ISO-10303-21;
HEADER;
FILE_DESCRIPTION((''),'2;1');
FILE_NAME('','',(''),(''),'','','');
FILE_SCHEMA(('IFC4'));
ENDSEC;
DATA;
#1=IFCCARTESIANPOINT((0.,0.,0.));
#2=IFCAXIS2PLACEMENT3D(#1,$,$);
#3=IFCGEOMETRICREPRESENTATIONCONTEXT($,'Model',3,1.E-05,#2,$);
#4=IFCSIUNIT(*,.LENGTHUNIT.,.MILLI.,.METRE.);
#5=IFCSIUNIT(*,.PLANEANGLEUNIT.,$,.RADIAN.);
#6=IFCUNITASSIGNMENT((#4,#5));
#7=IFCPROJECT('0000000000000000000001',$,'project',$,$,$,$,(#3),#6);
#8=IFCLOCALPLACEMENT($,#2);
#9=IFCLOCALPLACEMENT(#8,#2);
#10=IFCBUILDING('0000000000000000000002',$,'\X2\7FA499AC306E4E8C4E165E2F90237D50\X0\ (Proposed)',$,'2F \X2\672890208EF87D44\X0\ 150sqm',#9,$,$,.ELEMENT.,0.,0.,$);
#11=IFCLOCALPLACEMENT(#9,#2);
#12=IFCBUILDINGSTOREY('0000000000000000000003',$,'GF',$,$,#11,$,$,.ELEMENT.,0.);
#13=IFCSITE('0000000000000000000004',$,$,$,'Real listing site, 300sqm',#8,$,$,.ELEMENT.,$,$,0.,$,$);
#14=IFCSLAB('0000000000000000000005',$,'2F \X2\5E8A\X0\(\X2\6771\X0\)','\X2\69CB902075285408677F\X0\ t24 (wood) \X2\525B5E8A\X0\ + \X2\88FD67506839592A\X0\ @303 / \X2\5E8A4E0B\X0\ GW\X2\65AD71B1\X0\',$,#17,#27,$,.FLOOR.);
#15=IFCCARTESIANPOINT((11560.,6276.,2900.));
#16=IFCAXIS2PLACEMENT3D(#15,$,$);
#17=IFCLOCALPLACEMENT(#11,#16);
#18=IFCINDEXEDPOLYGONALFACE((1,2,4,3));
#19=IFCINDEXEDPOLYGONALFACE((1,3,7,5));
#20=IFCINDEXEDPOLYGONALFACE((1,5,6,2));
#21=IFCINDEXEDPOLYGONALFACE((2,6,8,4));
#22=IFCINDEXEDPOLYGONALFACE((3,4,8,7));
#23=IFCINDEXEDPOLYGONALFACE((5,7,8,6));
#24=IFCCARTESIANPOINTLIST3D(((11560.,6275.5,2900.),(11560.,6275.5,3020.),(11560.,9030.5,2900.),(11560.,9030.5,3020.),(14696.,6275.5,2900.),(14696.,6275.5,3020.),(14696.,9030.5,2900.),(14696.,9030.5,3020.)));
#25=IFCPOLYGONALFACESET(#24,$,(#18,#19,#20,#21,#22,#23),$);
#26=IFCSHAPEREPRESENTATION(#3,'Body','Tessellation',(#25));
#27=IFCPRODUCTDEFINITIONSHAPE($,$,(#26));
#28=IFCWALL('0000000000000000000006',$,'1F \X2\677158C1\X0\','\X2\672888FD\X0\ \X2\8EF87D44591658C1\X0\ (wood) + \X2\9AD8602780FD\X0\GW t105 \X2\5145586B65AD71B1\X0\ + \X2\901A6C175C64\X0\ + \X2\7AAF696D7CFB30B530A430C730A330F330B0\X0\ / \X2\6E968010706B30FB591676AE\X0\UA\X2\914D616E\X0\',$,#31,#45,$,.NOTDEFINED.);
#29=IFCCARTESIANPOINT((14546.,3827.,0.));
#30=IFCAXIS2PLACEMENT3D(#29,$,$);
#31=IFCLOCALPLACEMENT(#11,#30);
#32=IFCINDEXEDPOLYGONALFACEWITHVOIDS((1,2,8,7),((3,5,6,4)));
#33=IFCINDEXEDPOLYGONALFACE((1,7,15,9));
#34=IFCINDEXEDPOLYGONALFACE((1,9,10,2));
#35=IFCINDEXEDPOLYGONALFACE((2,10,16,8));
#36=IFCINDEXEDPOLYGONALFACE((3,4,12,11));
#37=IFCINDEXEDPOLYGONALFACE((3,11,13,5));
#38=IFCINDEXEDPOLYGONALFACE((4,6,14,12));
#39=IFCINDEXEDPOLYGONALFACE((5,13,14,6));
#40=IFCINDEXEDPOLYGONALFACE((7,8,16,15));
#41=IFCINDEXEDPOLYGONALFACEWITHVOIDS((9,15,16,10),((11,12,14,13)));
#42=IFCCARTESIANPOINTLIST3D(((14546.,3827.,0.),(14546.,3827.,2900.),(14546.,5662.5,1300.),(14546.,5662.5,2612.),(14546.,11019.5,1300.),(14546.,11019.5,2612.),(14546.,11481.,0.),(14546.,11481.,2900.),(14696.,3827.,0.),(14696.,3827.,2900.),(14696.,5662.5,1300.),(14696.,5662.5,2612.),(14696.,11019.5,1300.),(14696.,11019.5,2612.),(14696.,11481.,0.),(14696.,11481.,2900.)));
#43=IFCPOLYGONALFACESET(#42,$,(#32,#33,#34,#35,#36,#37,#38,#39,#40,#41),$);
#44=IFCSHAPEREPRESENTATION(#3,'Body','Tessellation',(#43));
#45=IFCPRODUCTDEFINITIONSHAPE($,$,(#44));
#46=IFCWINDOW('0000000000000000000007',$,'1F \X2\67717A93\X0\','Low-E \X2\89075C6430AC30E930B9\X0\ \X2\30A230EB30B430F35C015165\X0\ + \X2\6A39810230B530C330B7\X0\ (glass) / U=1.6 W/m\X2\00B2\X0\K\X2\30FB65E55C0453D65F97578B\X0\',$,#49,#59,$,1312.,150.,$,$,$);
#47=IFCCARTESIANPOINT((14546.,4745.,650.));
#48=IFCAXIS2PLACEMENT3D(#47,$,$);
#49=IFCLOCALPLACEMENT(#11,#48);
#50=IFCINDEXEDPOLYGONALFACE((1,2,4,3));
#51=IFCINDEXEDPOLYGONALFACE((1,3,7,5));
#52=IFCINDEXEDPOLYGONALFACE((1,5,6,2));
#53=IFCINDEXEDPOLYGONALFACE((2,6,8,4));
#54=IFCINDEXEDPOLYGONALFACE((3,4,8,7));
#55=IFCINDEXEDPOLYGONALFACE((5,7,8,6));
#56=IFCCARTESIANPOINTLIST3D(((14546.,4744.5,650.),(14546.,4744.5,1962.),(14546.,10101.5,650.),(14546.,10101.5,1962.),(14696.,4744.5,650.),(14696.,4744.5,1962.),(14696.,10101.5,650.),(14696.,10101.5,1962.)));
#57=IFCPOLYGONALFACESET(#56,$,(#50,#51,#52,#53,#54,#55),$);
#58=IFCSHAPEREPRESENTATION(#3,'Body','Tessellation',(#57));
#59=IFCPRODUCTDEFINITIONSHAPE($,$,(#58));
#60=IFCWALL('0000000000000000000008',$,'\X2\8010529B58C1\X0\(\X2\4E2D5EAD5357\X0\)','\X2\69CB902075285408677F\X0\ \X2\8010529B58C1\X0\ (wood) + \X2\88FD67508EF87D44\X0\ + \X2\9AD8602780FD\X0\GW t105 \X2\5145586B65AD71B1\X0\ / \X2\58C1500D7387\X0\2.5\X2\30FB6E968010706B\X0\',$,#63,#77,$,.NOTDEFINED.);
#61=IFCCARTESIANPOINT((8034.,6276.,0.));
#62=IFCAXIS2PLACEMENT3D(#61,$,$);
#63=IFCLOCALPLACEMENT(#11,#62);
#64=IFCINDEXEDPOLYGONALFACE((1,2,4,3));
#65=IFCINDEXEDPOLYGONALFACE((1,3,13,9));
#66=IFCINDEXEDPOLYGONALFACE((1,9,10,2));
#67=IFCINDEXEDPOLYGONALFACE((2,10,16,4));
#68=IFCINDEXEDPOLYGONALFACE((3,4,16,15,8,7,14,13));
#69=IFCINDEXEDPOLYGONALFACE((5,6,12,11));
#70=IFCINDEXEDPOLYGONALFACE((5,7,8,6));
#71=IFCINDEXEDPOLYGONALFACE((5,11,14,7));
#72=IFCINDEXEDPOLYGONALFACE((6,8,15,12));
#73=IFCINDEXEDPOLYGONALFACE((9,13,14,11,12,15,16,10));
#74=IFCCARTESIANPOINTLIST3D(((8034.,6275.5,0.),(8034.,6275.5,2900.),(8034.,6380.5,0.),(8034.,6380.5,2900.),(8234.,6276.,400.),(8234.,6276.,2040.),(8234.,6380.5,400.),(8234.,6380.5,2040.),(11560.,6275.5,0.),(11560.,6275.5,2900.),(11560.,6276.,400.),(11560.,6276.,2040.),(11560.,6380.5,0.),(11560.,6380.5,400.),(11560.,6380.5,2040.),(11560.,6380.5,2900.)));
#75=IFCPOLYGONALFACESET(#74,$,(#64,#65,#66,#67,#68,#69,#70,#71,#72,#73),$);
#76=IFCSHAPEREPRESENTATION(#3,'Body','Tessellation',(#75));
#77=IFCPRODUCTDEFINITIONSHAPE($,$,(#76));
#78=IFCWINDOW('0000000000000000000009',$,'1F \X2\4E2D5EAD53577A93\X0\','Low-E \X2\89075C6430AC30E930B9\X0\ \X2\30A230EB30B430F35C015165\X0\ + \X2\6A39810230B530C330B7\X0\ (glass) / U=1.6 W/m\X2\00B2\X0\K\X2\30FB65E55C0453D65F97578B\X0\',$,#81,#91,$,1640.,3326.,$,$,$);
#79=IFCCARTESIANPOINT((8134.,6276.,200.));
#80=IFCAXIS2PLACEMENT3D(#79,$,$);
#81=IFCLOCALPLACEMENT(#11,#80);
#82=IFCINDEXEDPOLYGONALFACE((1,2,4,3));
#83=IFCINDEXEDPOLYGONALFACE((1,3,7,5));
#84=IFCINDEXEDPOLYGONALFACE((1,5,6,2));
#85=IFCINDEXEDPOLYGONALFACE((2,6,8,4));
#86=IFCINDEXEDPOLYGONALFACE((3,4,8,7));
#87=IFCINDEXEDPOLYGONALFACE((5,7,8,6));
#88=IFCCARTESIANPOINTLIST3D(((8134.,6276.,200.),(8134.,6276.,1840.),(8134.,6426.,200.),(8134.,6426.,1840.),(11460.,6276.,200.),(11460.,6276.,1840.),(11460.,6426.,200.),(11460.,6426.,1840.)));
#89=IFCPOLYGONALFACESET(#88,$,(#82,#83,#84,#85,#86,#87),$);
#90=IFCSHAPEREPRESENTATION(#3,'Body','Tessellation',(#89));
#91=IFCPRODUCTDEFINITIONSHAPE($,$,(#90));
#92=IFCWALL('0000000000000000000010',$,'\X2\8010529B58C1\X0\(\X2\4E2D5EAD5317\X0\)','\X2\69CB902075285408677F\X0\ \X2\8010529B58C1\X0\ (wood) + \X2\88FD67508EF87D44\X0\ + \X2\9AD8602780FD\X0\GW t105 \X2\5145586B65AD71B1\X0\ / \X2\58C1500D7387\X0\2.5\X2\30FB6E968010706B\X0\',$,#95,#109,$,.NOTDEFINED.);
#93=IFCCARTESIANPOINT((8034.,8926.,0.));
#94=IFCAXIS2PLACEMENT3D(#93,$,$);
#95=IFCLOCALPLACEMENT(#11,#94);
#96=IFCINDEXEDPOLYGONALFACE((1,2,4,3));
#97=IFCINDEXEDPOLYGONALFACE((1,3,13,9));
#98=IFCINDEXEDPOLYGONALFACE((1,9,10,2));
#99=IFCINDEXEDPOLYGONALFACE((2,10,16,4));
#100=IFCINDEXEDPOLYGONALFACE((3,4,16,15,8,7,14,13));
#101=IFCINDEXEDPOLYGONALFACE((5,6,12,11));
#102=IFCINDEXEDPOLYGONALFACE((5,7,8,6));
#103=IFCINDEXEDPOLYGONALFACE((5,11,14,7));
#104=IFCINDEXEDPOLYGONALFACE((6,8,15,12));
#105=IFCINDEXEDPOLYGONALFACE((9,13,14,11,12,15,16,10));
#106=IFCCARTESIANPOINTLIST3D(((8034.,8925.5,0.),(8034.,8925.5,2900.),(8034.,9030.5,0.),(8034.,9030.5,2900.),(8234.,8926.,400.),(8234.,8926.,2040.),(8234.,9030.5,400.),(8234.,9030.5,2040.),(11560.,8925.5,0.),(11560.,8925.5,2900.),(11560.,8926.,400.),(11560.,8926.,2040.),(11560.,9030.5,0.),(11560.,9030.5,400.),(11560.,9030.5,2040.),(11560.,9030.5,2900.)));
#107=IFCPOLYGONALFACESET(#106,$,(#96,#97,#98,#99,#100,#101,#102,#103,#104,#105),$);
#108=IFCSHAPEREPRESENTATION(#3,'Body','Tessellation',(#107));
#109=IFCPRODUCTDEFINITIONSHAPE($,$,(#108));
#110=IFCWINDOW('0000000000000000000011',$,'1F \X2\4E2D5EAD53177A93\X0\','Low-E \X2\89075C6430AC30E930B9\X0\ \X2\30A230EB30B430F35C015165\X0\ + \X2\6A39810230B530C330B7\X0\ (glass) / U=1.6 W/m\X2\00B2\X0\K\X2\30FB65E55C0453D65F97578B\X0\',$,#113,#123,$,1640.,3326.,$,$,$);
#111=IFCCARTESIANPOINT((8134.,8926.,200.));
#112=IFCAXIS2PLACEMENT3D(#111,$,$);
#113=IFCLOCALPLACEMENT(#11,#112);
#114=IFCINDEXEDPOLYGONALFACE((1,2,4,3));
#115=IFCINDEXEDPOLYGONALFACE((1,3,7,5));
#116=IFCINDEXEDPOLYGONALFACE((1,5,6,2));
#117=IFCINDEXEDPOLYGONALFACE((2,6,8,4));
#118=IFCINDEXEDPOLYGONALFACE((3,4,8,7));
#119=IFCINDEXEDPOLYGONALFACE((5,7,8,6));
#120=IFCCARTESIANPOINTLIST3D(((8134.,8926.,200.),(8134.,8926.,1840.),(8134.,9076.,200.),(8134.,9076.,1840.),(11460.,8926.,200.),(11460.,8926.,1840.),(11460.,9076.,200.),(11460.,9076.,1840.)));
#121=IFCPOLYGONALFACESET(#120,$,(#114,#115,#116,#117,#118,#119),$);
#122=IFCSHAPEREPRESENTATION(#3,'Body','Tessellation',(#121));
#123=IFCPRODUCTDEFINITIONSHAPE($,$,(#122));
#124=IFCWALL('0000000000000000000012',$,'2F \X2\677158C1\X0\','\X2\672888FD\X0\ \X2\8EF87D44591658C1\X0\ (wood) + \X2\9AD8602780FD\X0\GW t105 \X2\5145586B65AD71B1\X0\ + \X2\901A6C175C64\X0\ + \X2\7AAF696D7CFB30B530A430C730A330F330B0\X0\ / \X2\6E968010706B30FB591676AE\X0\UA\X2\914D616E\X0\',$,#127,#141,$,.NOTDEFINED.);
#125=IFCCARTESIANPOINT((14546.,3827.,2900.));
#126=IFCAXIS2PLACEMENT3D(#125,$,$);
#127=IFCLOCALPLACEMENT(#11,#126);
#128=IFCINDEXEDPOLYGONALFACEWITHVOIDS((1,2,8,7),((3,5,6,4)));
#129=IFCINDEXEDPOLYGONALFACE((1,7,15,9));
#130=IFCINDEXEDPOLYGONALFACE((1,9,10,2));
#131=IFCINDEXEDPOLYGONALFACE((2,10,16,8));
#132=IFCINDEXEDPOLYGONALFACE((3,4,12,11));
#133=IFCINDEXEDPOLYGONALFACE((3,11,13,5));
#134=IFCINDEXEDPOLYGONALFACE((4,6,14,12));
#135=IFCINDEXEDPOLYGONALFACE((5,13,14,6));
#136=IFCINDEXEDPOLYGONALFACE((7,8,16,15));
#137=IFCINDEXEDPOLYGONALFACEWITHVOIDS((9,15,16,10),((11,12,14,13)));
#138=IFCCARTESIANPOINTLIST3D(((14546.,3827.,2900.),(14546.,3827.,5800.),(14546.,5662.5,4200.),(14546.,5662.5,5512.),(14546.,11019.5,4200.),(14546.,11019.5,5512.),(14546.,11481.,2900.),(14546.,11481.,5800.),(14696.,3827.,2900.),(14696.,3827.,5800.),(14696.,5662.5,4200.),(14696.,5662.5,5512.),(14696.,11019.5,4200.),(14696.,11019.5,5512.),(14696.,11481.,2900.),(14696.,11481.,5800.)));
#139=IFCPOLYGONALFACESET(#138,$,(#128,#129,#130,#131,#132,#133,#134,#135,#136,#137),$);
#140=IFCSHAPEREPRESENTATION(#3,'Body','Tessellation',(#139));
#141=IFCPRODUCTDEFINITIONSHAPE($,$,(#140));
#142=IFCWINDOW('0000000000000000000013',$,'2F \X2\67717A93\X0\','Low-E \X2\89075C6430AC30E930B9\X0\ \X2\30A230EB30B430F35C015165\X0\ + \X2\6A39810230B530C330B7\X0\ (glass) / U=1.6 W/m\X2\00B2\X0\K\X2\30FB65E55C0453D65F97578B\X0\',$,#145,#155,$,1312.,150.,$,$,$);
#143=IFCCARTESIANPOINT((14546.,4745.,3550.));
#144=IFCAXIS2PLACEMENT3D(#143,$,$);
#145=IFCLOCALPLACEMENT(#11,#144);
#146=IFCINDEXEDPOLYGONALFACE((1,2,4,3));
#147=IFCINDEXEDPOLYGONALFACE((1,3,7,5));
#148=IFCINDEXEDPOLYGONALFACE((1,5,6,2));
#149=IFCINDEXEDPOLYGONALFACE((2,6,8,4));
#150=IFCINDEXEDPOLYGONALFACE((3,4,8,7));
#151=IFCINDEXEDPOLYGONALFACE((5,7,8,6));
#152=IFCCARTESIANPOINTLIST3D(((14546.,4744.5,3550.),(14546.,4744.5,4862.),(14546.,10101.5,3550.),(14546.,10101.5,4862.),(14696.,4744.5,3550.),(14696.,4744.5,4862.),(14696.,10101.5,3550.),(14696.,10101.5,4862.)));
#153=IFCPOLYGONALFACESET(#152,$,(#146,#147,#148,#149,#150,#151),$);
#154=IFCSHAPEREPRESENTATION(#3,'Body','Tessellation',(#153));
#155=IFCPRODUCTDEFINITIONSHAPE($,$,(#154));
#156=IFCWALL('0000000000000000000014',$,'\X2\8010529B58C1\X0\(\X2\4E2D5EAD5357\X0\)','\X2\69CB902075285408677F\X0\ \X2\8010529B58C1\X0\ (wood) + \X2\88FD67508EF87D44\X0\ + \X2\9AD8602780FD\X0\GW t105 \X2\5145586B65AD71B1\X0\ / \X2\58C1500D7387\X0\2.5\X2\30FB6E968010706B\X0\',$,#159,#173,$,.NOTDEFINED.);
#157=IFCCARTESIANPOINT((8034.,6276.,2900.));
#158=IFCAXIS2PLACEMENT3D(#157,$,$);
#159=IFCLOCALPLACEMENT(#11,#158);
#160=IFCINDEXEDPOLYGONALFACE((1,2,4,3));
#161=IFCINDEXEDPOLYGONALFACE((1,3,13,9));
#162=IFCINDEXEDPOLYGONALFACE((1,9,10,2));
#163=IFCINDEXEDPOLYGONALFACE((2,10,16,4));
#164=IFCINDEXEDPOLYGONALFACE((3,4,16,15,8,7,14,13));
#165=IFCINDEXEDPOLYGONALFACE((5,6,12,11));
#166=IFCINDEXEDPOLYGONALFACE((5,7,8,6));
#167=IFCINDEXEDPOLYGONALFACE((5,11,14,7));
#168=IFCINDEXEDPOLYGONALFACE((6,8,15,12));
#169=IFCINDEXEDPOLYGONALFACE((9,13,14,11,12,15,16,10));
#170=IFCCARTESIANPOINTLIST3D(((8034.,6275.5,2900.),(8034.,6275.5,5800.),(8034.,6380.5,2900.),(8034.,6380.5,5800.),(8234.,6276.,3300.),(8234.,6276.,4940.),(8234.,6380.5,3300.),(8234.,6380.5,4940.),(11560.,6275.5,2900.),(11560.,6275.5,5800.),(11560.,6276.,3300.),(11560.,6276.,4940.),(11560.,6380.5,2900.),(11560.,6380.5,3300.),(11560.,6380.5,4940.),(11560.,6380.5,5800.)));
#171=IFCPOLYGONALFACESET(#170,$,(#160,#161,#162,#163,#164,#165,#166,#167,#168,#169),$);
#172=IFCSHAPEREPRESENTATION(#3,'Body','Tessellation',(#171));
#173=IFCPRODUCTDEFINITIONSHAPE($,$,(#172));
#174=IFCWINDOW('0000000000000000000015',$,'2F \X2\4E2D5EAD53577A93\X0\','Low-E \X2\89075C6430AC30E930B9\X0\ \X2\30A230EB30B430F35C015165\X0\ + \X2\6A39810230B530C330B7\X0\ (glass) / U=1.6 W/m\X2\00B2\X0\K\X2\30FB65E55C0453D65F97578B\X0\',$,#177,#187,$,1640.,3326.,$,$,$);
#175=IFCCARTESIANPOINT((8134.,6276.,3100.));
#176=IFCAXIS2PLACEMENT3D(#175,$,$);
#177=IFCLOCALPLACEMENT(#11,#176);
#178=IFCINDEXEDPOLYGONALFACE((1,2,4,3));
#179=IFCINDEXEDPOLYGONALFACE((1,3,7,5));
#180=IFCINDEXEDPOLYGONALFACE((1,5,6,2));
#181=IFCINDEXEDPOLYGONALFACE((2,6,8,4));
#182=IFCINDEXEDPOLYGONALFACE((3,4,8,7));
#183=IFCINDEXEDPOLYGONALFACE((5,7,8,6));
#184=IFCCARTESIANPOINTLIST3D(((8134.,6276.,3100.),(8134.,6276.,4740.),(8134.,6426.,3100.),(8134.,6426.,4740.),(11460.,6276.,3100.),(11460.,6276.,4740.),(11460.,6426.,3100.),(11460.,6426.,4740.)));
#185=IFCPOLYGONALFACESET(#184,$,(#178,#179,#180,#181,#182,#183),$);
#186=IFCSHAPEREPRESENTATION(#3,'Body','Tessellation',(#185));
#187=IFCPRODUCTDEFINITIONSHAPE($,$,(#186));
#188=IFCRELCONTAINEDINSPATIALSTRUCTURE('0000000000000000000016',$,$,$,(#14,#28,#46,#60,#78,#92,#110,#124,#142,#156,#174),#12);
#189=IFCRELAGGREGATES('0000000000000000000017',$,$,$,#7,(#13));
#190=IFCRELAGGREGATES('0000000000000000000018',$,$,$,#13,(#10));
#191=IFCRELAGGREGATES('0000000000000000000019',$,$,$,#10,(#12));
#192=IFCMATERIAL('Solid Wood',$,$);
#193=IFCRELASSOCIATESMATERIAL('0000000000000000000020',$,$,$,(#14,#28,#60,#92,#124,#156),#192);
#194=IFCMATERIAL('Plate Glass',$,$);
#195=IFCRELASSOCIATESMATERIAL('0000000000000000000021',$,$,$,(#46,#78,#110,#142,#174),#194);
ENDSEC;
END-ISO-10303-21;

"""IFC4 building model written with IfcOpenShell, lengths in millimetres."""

from ifc_helpers import new_model, si_unit, frame, frame_2d, origin, place, context, project, spatial, rectangle, extrude, material, element, fill, save


model = new_model("IFC4")

# Units and contexts
model_context = context("Model", 3, precision=1e-05, world=origin())
ifc_project = project(units=[si_unit("LENGTHUNIT", "METRE", prefix="MILLI"), si_unit("PLANEANGLEUNIT", "RADIAN")], contexts=[model_context])

# Site, building, storey
site_placement = place(None, origin())
site = spatial("IfcSite", under=ifc_project, at=site_placement, ObjectType="Real listing site, 300sqm", CompositionType="ELEMENT", RefElevation=0.0)
building_placement = place(site_placement, origin())
building = spatial("IfcBuilding", under=site, at=building_placement, Name="群馬の二世帯連結 (Proposed)", ObjectType="2F 木造軸組 150sqm", CompositionType="ELEMENT", ElevationOfRefHeight=0.0, ElevationOfTerrain=0.0)
storey_placement = place(building_placement, origin())
storey = spatial("IfcBuildingStorey", under=building, at=storey_placement, Name="GF", CompositionType="ELEMENT", Elevation=0.0)

# Slab
ifc_material_1 = material(Name="Solid Wood")
slab_1_placement = place(storey_placement, frame((11560.0, 6276.0, 2900.0)))
element("IfcSlab", 1, at=slab_1_placement, inside=storey, material=ifc_material_1, Name="2F 床(東)", Description="構造用合板 t24 (wood) 剛床 + 製材根太 @303 / 床下 GW断熱", PredefinedType="FLOOR", context=model_context, shape_type="SweptSolid", body=[
    extrude(rectangle(XDim=3136.0, YDim=2755.0, at=frame_2d((1568.0, 1377.0))), frame((11560.0, 6276.0, 2900.0)), (0.0, 0.0, 1.0), 120.0),
])

# Walls, openings, windows
wall_1_placement = place(storey_placement, frame((14546.0, 3827.0, 0.0)))
wall_1 = element("IfcWall", 2, at=wall_1_placement, inside=storey, material=ifc_material_1, Name="1F 東壁", Description="木製 軸組外壁 (wood) + 高性能GW t105 充填断熱 + 通気層 + 窯業系サイディング / 準耐火・外皮UA配慮", PredefinedType="NOTDEFINED", context=model_context, shape_type="SweptSolid", body=[
    extrude(rectangle(XDim=150.0, YDim=7654.0, at=frame_2d((75.0, 3827.0))), frame((14546.0, 3827.0, 0.0)), (0.0, 0.0, 1.0), 2900.0),
])
opening_1_placement = place(storey_placement, frame((14546.0, 4745.0, 650.0)))
opening_1 = element("IfcOpeningElement", 3, at=opening_1_placement, cuts=wall_1, PredefinedType="NOTDEFINED", context=model_context, shape_type="SweptSolid", body=[
    extrude(rectangle(XDim=150.0, YDim=5357.0, at=frame_2d((75.0, 2678.0))), frame((14546.0, 4745.0, 650.0)), (0.0, 0.0, 1.0), 1312.0),
])
ifc_material_2 = material(Name="Plate Glass")
window_1_placement = place(storey_placement, frame((14546.0, 4745.0, 650.0)))
window_1 = element("IfcWindow", 4, at=window_1_placement, inside=storey, material=ifc_material_2, Name="1F 東窓", Description="Low-E 複層ガラス アルゴン封入 + 樹脂サッシ (glass) / U=1.6 W/m²K・日射取得型", OverallHeight=1312.0, OverallWidth=150.0, context=model_context, shape_type="SweptSolid", body=[
    extrude(rectangle(XDim=150.0, YDim=5357.0, at=frame_2d((75.0, 2678.0))), frame((14546.0, 4745.0, 650.0)), (0.0, 0.0, 1.0), 1312.0),
])
fill(opening_1, window_1)
wall_2_placement = place(storey_placement, frame((8034.0, 6276.0, 0.0)))
wall_2 = element("IfcWall", 5, at=wall_2_placement, inside=storey, material=ifc_material_1, Name="耐力壁(中庭南)", Description="構造用合板 耐力壁 (wood) + 製材軸組 + 高性能GW t105 充填断熱 / 壁倍率2.5・準耐火", PredefinedType="NOTDEFINED", context=model_context, shape_type="SweptSolid", body=[
    extrude(rectangle(XDim=3526.0, YDim=105.0, at=frame_2d((1763.0, 52.0))), frame((8034.0, 6276.0, 0.0)), (0.0, 0.0, 1.0), 2900.0),
])
opening_2_placement = place(storey_placement, frame((8134.0, 6276.0, 200.0)))
opening_2 = element("IfcOpeningElement", 6, at=opening_2_placement, cuts=wall_2, PredefinedType="NOTDEFINED", context=model_context, shape_type="SweptSolid", body=[
    extrude(rectangle(XDim=3326.0, YDim=150.0, at=frame_2d((1663.0, 75.0))), frame((8134.0, 6276.0, 200.0)), (0.0, 0.0, 1.0), 1640.0),
])
window_2_placement = place(storey_placement, frame((8134.0, 6276.0, 200.0)))
window_2 = element("IfcWindow", 7, at=window_2_placement, inside=storey, material=ifc_material_2, Name="1F 中庭南窓", Description="Low-E 複層ガラス アルゴン封入 + 樹脂サッシ (glass) / U=1.6 W/m²K・日射取得型", OverallHeight=1640.0, OverallWidth=3326.0, context=model_context, shape_type="SweptSolid", body=[
    extrude(rectangle(XDim=3326.0, YDim=150.0, at=frame_2d((1663.0, 75.0))), frame((8134.0, 6276.0, 200.0)), (0.0, 0.0, 1.0), 1640.0),
])
fill(opening_2, window_2)
wall_3_placement = place(storey_placement, frame((8034.0, 8926.0, 0.0)))
wall_3 = element("IfcWall", 8, at=wall_3_placement, inside=storey, material=ifc_material_1, Name="耐力壁(中庭北)", Description="構造用合板 耐力壁 (wood) + 製材軸組 + 高性能GW t105 充填断熱 / 壁倍率2.5・準耐火", PredefinedType="NOTDEFINED", context=model_context, shape_type="SweptSolid", body=[
    extrude(rectangle(XDim=3526.0, YDim=105.0, at=frame_2d((1763.0, 52.0))), frame((8034.0, 8926.0, 0.0)), (0.0, 0.0, 1.0), 2900.0),
])
opening_3_placement = place(storey_placement, frame((8134.0, 8926.0, 200.0)))
opening_3 = element("IfcOpeningElement", 9, at=opening_3_placement, cuts=wall_3, PredefinedType="NOTDEFINED", context=model_context, shape_type="SweptSolid", body=[
    extrude(rectangle(XDim=3326.0, YDim=150.0, at=frame_2d((1663.0, 75.0))), frame((8134.0, 8926.0, 200.0)), (0.0, 0.0, 1.0), 1640.0),
])
window_3_placement = place(storey_placement, frame((8134.0, 8926.0, 200.0)))
window_3 = element("IfcWindow", 10, at=window_3_placement, inside=storey, material=ifc_material_2, Name="1F 中庭北窓", Description="Low-E 複層ガラス アルゴン封入 + 樹脂サッシ (glass) / U=1.6 W/m²K・日射取得型", OverallHeight=1640.0, OverallWidth=3326.0, context=model_context, shape_type="SweptSolid", body=[
    extrude(rectangle(XDim=3326.0, YDim=150.0, at=frame_2d((1663.0, 75.0))), frame((8134.0, 8926.0, 200.0)), (0.0, 0.0, 1.0), 1640.0),
])
fill(opening_3, window_3)

# Walls, openings, windows
wall_4_placement = place(storey_placement, frame((14546.0, 3827.0, 2900.0)))
wall_4 = element("IfcWall", 11, at=wall_4_placement, inside=storey, material=ifc_material_1, Name="2F 東壁", Description="木製 軸組外壁 (wood) + 高性能GW t105 充填断熱 + 通気層 + 窯業系サイディング / 準耐火・外皮UA配慮", PredefinedType="NOTDEFINED", context=model_context, shape_type="SweptSolid", body=[
    extrude(rectangle(XDim=150.0, YDim=7654.0, at=frame_2d((75.0, 3827.0))), frame((14546.0, 3827.0, 2900.0)), (0.0, 0.0, 1.0), 2900.0),
])
opening_4_placement = place(storey_placement, frame((14546.0, 4745.0, 3550.0)))
opening_4 = element("IfcOpeningElement", 12, at=opening_4_placement, cuts=wall_4, PredefinedType="NOTDEFINED", context=model_context, shape_type="SweptSolid", body=[
    extrude(rectangle(XDim=150.0, YDim=5357.0, at=frame_2d((75.0, 2678.0))), frame((14546.0, 4745.0, 3550.0)), (0.0, 0.0, 1.0), 1312.0),
])
window_4_placement = place(storey_placement, frame((14546.0, 4745.0, 3550.0)))
window_4 = element("IfcWindow", 13, at=window_4_placement, inside=storey, material=ifc_material_2, Name="2F 東窓", Description="Low-E 複層ガラス アルゴン封入 + 樹脂サッシ (glass) / U=1.6 W/m²K・日射取得型", OverallHeight=1312.0, OverallWidth=150.0, context=model_context, shape_type="SweptSolid", body=[
    extrude(rectangle(XDim=150.0, YDim=5357.0, at=frame_2d((75.0, 2678.0))), frame((14546.0, 4745.0, 3550.0)), (0.0, 0.0, 1.0), 1312.0),
])
fill(opening_4, window_4)
wall_5_placement = place(storey_placement, frame((8034.0, 6276.0, 2900.0)))
wall_5 = element("IfcWall", 14, at=wall_5_placement, inside=storey, material=ifc_material_1, Name="耐力壁(中庭南)", Description="構造用合板 耐力壁 (wood) + 製材軸組 + 高性能GW t105 充填断熱 / 壁倍率2.5・準耐火", PredefinedType="NOTDEFINED", context=model_context, shape_type="SweptSolid", body=[
    extrude(rectangle(XDim=3526.0, YDim=105.0, at=frame_2d((1763.0, 52.0))), frame((8034.0, 6276.0, 2900.0)), (0.0, 0.0, 1.0), 2900.0),
])
opening_5_placement = place(storey_placement, frame((8134.0, 6276.0, 3100.0)))
opening_5 = element("IfcOpeningElement", 15, at=opening_5_placement, cuts=wall_5, PredefinedType="NOTDEFINED", context=model_context, shape_type="SweptSolid", body=[
    extrude(rectangle(XDim=3326.0, YDim=150.0, at=frame_2d((1663.0, 75.0))), frame((8134.0, 6276.0, 3100.0)), (0.0, 0.0, 1.0), 1640.0),
])
window_5_placement = place(storey_placement, frame((8134.0, 6276.0, 3100.0)))
window_5 = element("IfcWindow", 16, at=window_5_placement, inside=storey, material=ifc_material_2, Name="2F 中庭南窓", Description="Low-E 複層ガラス アルゴン封入 + 樹脂サッシ (glass) / U=1.6 W/m²K・日射取得型", OverallHeight=1640.0, OverallWidth=3326.0, context=model_context, shape_type="SweptSolid", body=[
    extrude(rectangle(XDim=3326.0, YDim=150.0, at=frame_2d((1663.0, 75.0))), frame((8134.0, 6276.0, 3100.0)), (0.0, 0.0, 1.0), 1640.0),
])
fill(opening_5, window_5)

save(model, "model.ifc")
